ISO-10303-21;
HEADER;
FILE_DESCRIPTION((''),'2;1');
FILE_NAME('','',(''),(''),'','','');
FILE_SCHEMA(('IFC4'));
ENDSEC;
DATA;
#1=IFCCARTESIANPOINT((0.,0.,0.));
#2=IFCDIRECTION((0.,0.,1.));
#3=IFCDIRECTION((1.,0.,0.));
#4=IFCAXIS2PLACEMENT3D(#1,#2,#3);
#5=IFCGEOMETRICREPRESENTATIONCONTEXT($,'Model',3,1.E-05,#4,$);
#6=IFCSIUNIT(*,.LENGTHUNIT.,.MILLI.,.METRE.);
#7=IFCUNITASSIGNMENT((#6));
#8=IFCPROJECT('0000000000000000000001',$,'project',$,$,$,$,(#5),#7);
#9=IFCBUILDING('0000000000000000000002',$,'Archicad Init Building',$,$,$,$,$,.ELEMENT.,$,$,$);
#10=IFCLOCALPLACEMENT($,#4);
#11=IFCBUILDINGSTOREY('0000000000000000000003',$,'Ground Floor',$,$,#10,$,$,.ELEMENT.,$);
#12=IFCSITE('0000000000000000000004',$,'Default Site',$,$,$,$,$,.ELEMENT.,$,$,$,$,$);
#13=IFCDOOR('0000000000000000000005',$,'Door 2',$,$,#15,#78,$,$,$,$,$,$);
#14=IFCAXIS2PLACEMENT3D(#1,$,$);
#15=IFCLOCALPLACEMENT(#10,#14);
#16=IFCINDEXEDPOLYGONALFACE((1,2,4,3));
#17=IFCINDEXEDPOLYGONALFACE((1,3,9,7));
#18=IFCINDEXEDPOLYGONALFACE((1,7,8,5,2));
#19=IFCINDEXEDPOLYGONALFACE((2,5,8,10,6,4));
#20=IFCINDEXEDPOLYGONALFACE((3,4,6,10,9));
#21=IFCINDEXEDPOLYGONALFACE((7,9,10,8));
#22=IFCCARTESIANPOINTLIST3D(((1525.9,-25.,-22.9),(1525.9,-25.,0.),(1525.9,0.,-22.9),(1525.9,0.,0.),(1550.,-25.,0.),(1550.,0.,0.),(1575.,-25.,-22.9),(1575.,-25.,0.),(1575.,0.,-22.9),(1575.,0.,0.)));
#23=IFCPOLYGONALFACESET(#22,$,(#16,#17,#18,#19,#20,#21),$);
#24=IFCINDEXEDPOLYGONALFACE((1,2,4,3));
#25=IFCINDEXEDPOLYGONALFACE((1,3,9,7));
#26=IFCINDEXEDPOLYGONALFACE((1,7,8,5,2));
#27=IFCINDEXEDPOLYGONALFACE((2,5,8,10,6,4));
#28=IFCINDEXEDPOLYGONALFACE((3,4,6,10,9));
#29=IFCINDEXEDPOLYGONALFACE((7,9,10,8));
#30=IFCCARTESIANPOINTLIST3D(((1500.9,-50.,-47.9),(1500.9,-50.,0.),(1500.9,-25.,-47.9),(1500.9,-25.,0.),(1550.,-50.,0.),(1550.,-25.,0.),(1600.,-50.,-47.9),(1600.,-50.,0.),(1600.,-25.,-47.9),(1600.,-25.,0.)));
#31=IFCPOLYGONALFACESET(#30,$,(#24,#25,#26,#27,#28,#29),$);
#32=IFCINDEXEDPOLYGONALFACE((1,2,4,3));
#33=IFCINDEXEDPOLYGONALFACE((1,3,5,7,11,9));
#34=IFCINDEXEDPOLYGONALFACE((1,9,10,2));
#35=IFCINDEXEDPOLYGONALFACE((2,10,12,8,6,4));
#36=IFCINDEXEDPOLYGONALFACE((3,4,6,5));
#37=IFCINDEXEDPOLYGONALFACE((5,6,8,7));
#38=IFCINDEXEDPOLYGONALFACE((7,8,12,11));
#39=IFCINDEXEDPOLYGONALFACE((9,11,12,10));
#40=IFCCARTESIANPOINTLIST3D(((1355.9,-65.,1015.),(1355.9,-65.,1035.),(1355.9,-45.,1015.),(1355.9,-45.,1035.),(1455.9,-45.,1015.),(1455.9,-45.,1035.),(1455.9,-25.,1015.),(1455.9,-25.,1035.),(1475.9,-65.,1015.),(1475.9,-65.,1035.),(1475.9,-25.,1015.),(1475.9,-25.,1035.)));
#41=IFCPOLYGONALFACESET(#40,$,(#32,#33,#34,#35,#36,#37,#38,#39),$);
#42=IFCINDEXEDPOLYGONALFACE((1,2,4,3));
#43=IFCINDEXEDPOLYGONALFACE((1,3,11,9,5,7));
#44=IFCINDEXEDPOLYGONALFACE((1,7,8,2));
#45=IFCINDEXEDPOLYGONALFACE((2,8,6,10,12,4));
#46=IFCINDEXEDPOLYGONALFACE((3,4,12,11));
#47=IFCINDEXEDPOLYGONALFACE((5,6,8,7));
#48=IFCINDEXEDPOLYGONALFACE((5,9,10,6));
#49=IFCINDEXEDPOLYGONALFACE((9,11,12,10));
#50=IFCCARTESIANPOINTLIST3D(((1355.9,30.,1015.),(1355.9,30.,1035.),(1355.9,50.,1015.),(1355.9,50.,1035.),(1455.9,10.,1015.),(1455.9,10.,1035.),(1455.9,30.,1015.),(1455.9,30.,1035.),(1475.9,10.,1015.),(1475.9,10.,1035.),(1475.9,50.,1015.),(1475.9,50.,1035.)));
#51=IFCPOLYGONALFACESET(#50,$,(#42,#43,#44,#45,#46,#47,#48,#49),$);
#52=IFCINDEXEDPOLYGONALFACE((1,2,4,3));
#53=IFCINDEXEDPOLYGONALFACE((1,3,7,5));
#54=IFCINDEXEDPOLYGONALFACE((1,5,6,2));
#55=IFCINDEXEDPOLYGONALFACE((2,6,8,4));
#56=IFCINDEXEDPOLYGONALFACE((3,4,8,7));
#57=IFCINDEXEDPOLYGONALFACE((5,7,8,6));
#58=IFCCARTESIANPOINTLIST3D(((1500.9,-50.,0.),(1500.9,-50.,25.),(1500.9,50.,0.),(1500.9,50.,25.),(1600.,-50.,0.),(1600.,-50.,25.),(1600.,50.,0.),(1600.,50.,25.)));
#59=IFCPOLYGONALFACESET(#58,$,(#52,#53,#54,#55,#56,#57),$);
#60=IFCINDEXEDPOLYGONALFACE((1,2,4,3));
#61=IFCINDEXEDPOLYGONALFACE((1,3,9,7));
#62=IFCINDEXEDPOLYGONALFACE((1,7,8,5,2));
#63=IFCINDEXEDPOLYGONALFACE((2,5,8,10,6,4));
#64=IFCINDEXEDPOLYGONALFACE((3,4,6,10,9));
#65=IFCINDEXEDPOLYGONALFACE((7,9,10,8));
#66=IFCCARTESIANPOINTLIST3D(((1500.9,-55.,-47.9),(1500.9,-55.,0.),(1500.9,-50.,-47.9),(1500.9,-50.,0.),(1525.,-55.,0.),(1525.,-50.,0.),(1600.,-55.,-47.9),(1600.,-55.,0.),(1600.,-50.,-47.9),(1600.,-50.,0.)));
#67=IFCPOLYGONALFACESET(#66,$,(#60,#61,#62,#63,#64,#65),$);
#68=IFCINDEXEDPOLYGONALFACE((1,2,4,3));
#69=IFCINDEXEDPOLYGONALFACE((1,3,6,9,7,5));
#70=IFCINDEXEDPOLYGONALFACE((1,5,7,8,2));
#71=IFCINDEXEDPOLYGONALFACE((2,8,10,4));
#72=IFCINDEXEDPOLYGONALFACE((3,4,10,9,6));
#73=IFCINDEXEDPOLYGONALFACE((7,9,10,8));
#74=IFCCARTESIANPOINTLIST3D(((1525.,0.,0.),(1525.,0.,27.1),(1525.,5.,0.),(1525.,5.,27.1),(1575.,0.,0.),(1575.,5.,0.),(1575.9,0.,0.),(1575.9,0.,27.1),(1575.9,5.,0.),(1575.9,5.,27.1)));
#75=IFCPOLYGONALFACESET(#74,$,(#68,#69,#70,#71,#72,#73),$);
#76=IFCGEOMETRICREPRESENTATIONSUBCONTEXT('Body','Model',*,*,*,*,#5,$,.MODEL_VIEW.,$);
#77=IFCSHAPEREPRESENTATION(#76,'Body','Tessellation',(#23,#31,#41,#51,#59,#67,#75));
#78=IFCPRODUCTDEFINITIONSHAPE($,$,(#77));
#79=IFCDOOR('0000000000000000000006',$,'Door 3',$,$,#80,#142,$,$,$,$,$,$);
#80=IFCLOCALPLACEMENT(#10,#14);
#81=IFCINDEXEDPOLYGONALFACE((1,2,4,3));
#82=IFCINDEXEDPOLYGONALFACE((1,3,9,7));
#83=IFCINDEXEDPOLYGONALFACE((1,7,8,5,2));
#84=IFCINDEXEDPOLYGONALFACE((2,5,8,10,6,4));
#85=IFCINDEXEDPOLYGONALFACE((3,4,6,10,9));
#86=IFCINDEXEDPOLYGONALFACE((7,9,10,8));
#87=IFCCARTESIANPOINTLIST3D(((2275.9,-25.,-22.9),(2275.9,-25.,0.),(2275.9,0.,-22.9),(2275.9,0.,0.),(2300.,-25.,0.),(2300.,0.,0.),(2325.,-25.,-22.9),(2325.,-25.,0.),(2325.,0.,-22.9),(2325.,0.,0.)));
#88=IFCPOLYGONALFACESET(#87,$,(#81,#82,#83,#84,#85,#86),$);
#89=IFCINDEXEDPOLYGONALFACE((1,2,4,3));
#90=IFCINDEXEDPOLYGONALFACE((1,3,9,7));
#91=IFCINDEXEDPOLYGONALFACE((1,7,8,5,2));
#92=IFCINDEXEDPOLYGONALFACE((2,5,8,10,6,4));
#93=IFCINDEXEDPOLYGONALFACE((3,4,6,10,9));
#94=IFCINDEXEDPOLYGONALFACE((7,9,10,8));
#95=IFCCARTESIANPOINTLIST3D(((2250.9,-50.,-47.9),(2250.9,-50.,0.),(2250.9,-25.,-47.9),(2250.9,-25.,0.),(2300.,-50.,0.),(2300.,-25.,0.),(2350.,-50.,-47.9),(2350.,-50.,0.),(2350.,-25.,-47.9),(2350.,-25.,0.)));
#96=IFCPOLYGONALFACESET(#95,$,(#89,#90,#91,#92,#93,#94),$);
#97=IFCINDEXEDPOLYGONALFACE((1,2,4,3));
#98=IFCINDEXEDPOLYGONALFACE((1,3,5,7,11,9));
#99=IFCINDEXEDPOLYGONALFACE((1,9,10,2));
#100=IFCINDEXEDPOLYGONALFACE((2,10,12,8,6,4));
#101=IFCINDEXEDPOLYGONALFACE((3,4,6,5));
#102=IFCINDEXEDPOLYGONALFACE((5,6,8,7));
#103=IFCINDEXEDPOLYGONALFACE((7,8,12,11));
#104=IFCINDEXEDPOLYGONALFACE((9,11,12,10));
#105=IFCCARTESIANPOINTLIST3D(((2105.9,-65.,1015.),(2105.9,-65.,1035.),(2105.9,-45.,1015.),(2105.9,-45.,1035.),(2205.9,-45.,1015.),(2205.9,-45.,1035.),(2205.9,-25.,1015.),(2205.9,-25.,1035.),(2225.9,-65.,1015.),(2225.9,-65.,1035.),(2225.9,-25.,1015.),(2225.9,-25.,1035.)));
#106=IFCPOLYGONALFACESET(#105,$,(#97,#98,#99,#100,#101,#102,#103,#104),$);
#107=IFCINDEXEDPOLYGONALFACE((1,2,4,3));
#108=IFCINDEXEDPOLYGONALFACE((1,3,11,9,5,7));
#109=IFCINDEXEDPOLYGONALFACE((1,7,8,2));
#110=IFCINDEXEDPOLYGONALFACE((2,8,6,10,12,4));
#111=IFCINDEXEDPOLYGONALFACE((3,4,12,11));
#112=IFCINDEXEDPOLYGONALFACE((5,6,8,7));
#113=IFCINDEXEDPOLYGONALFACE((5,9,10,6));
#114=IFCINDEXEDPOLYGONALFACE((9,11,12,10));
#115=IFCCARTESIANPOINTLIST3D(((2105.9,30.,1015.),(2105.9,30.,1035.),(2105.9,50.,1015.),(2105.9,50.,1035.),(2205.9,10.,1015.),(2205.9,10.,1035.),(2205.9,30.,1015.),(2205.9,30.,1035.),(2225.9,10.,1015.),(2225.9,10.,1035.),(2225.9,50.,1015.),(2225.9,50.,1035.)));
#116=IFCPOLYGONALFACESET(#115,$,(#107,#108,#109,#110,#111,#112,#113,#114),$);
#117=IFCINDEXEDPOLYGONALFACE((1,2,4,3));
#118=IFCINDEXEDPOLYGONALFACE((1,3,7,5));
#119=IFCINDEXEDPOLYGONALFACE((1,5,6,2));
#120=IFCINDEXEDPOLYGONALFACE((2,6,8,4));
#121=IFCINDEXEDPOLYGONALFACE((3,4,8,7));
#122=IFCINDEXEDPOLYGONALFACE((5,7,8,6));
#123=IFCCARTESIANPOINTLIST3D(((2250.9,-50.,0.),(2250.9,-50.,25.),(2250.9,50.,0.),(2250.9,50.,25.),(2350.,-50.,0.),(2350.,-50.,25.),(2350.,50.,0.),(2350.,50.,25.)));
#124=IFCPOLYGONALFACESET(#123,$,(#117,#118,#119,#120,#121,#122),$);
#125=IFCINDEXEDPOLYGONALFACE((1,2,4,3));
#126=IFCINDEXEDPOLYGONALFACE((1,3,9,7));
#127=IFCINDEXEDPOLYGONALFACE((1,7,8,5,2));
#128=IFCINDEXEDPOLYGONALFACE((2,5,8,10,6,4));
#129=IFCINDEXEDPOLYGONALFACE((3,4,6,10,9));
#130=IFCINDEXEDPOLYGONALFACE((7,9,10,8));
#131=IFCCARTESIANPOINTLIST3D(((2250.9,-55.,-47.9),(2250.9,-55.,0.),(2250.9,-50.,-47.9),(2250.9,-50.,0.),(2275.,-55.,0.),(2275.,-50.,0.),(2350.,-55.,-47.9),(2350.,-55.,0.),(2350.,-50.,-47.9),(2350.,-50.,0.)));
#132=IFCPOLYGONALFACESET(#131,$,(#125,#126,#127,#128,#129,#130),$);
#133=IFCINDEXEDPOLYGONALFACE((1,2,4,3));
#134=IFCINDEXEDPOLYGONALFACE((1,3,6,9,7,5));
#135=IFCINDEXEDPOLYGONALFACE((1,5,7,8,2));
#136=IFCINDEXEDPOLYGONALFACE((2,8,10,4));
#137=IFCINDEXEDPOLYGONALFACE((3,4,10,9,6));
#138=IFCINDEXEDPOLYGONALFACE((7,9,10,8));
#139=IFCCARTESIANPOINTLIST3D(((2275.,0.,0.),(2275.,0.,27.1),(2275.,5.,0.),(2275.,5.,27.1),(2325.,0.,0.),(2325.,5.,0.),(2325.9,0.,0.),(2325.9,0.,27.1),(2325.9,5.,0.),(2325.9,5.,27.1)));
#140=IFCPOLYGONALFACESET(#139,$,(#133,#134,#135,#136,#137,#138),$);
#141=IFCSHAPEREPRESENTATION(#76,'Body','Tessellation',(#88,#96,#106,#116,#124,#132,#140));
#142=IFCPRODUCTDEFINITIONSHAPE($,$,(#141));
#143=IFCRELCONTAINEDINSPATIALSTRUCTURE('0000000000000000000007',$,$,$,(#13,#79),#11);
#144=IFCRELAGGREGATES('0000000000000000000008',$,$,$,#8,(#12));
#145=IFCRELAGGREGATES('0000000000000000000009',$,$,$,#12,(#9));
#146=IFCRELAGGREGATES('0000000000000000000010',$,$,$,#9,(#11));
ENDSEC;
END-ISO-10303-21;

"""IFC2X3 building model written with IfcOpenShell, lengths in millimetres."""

from ifc_helpers import new_model, si_unit, frame, origin_with_axes, place, context, subcontext, project, spatial, polyline, outline, extrude, element, save


model = new_model("IFC2X3")

# Units and contexts
model_context = context("Model", 3, precision=1e-05, world=origin_with_axes())
body_context = subcontext(model_context, "Body", "Model", "MODEL_VIEW")
ifc_project = project(units=[si_unit("LENGTHUNIT", "METRE", prefix="MILLI")], contexts=[model_context])

# Site, building, storey
site = spatial("IfcSite", under=ifc_project, Name="Default Site", CompositionType="ELEMENT")
building = spatial("IfcBuilding", under=site, Name="Archicad Init Building", CompositionType="ELEMENT")
storey_placement = place(None, origin_with_axes())
storey = spatial("IfcBuildingStorey", under=building, at=storey_placement, Name="Ground Floor", CompositionType="ELEMENT")

# Doors
door_1_placement = place(storey_placement, frame((1550.0, -50.0, 0.0), z_axis=(0.0, 0.0, 1.0), x_axis=(1.0, 0.0, 0.0)))
element("IfcDoor", 1, at=door_1_placement, inside=storey, Name="Door 2", context=body_context, shape_type="SweptSolid", body=[
    extrude(outline(polyline([(0.0, 0.0), (0.0, 2.1), (0.9, 2.1), (0.9, 0.0), (-24.1, 0.0), (-24.1, -22.9), (25.0, -22.9), (25.0, 0.0), (0.0, 0.0)])), frame((0.0, 25.0, 0.0), z_axis=(0.0, -1.0, 0.0), x_axis=(1.0, 0.0, 0.0)), (0.0, 0.0, -1.0), 25.0),
    extrude(outline(polyline([(0.0, 0.0), (0.0, 2.1), (0.9, 2.1), (0.9, 0.0), (-49.1, 0.0), (-49.1, -47.9), (50.0, -47.9), (50.0, 0.0), (0.0, 0.0)])), frame((0.0, 0.0, 0.0), z_axis=(0.0, -1.0, 0.0), x_axis=(1.0, 0.0, 0.0)), (0.0, 0.0, -1.0), 25.0),
    extrude(outline(polyline([(0.0, 0.0), (-49.1, 0.0), (-49.1, 35.0), (0.0, 35.0), (0.0, 0.0)])), frame((25.0, 25.0, 25.0), z_axis=(0.0, 0.0, 1.0), x_axis=(1.0, 0.0, 0.0)), (0.0, 0.0, 1.0), -47.9),
    extrude(outline(polyline([(0.0, 0.0), (0.0, -40.0), (-120.0, -40.0), (-120.0, -20.0), (-20.0, -20.0), (-20.0, 0.0), (0.0, 0.0)])), frame((-74.1, 25.0, 1015.0), z_axis=(0.0, 0.0, 1.0), x_axis=(1.0, 0.0, 0.0)), (0.0, 0.0, 1.0), 20.0),
    extrude(outline(polyline([(0.0, 0.0), (0.0, 40.0), (-120.0, 40.0), (-120.0, 20.0), (-20.0, 20.0), (-20.0, 0.0), (0.0, 0.0)])), frame((-74.1, 60.0, 1015.0), z_axis=(0.0, 0.0, 1.0), x_axis=(1.0, 0.0, 0.0)), (0.0, 0.0, 1.0), 20.0),
    extrude(outline(polyline([(0.0, 0.0), (-99.1, 0.0), (-99.1, 100.0), (0.0, 100.0), (0.0, 0.0)])), frame((50.0, 0.0, 0.0), z_axis=(0.0, 0.0, 1.0), x_axis=(1.0, 0.0, 0.0)), (0.0, 0.0, 1.0), 25.0),
    extrude(outline(polyline([(0.0, 0.0), (0.0, 27.1), (50.9, 27.1), (50.9, 0.0), (-24.1, 0.0), (-24.1, -47.9), (75.0, -47.9), (75.0, 0.0), (0.0, 0.0)])), frame((-25.0, -5.0, 0.0), z_axis=(0.0, -1.0, 0.0), x_axis=(1.0, 0.0, 0.0)), (0.0, 0.0, -1.0), 5.0),
    extrude(outline(polyline([(0.0, 0.0), (0.0, 27.1), (50.9, 27.1), (50.9, 0.0), (0.9, 0.0), (0.9, -22.9), (50.0, -22.9), (50.0, 0.0), (0.0, 0.0)])), frame((-25.0, 50.0, 0.0), z_axis=(0.0, -1.0, 0.0), x_axis=(1.0, 0.0, 0.0)), (0.0, 0.0, -1.0), 5.0),
])
door_2_placement = place(storey_placement, frame((2300.0, -50.0, 0.0), z_axis=(0.0, 0.0, 1.0), x_axis=(1.0, 0.0, 0.0)))
element("IfcDoor", 2, at=door_2_placement, inside=storey, Name="Door 3", context=body_context, shape_type="SweptSolid", body=[
    extrude(outline(polyline([(0.0, 0.0), (0.0, 2.1), (0.9, 2.1), (0.9, 0.0), (-24.1, 0.0), (-24.1, -22.9), (25.0, -22.9), (25.0, 0.0), (0.0, 0.0)])), frame((0.0, 25.0, 0.0), z_axis=(0.0, -1.0, 0.0), x_axis=(1.0, 0.0, 0.0)), (0.0, 0.0, -1.0), 25.0),
    extrude(outline(polyline([(0.0, 0.0), (0.0, 2.1), (0.9, 2.1), (0.9, 0.0), (-49.1, 0.0), (-49.1, -47.9), (50.0, -47.9), (50.0, 0.0), (0.0, 0.0)])), frame((0.0, 0.0, 0.0), z_axis=(0.0, -1.0, 0.0), x_axis=(1.0, 0.0, 0.0)), (0.0, 0.0, -1.0), 25.0),
    extrude(outline(polyline([(0.0, 0.0), (-49.1, 0.0), (-49.1, 35.0), (0.0, 35.0), (0.0, 0.0)])), frame((25.0, 25.0, 25.0), z_axis=(0.0, 0.0, 1.0), x_axis=(1.0, 0.0, 0.0)), (0.0, 0.0, 1.0), -47.9),
    extrude(outline(polyline([(0.0, 0.0), (0.0, -40.0), (-120.0, -40.0), (-120.0, -20.0), (-20.0, -20.0), (-20.0, 0.0), (0.0, 0.0)])), frame((-74.1, 25.0, 1015.0), z_axis=(0.0, 0.0, 1.0), x_axis=(1.0, 0.0, 0.0)), (0.0, 0.0, 1.0), 20.0),
    extrude(outline(polyline([(0.0, 0.0), (0.0, 40.0), (-120.0, 40.0), (-120.0, 20.0), (-20.0, 20.0), (-20.0, 0.0), (0.0, 0.0)])), frame((-74.1, 60.0, 1015.0), z_axis=(0.0, 0.0, 1.0), x_axis=(1.0, 0.0, 0.0)), (0.0, 0.0, 1.0), 20.0),
    extrude(outline(polyline([(0.0, 0.0), (-99.1, 0.0), (-99.1, 100.0), (0.0, 100.0), (0.0, 0.0)])), frame((50.0, 0.0, 0.0), z_axis=(0.0, 0.0, 1.0), x_axis=(1.0, 0.0, 0.0)), (0.0, 0.0, 1.0), 25.0),
    extrude(outline(polyline([(0.0, 0.0), (0.0, 27.1), (50.9, 27.1), (50.9, 0.0), (-24.1, 0.0), (-24.1, -47.9), (75.0, -47.9), (75.0, 0.0), (0.0, 0.0)])), frame((-25.0, -5.0, 0.0), z_axis=(0.0, -1.0, 0.0), x_axis=(1.0, 0.0, 0.0)), (0.0, 0.0, -1.0), 5.0),
    extrude(outline(polyline([(0.0, 0.0), (0.0, 27.1), (50.9, 27.1), (50.9, 0.0), (0.9, 0.0), (0.9, -22.9), (50.0, -22.9), (50.0, 0.0), (0.0, 0.0)])), frame((-25.0, 50.0, 0.0), z_axis=(0.0, -1.0, 0.0), x_axis=(1.0, 0.0, 0.0)), (0.0, 0.0, -1.0), 5.0),
])

save(model, "model.ifc")
